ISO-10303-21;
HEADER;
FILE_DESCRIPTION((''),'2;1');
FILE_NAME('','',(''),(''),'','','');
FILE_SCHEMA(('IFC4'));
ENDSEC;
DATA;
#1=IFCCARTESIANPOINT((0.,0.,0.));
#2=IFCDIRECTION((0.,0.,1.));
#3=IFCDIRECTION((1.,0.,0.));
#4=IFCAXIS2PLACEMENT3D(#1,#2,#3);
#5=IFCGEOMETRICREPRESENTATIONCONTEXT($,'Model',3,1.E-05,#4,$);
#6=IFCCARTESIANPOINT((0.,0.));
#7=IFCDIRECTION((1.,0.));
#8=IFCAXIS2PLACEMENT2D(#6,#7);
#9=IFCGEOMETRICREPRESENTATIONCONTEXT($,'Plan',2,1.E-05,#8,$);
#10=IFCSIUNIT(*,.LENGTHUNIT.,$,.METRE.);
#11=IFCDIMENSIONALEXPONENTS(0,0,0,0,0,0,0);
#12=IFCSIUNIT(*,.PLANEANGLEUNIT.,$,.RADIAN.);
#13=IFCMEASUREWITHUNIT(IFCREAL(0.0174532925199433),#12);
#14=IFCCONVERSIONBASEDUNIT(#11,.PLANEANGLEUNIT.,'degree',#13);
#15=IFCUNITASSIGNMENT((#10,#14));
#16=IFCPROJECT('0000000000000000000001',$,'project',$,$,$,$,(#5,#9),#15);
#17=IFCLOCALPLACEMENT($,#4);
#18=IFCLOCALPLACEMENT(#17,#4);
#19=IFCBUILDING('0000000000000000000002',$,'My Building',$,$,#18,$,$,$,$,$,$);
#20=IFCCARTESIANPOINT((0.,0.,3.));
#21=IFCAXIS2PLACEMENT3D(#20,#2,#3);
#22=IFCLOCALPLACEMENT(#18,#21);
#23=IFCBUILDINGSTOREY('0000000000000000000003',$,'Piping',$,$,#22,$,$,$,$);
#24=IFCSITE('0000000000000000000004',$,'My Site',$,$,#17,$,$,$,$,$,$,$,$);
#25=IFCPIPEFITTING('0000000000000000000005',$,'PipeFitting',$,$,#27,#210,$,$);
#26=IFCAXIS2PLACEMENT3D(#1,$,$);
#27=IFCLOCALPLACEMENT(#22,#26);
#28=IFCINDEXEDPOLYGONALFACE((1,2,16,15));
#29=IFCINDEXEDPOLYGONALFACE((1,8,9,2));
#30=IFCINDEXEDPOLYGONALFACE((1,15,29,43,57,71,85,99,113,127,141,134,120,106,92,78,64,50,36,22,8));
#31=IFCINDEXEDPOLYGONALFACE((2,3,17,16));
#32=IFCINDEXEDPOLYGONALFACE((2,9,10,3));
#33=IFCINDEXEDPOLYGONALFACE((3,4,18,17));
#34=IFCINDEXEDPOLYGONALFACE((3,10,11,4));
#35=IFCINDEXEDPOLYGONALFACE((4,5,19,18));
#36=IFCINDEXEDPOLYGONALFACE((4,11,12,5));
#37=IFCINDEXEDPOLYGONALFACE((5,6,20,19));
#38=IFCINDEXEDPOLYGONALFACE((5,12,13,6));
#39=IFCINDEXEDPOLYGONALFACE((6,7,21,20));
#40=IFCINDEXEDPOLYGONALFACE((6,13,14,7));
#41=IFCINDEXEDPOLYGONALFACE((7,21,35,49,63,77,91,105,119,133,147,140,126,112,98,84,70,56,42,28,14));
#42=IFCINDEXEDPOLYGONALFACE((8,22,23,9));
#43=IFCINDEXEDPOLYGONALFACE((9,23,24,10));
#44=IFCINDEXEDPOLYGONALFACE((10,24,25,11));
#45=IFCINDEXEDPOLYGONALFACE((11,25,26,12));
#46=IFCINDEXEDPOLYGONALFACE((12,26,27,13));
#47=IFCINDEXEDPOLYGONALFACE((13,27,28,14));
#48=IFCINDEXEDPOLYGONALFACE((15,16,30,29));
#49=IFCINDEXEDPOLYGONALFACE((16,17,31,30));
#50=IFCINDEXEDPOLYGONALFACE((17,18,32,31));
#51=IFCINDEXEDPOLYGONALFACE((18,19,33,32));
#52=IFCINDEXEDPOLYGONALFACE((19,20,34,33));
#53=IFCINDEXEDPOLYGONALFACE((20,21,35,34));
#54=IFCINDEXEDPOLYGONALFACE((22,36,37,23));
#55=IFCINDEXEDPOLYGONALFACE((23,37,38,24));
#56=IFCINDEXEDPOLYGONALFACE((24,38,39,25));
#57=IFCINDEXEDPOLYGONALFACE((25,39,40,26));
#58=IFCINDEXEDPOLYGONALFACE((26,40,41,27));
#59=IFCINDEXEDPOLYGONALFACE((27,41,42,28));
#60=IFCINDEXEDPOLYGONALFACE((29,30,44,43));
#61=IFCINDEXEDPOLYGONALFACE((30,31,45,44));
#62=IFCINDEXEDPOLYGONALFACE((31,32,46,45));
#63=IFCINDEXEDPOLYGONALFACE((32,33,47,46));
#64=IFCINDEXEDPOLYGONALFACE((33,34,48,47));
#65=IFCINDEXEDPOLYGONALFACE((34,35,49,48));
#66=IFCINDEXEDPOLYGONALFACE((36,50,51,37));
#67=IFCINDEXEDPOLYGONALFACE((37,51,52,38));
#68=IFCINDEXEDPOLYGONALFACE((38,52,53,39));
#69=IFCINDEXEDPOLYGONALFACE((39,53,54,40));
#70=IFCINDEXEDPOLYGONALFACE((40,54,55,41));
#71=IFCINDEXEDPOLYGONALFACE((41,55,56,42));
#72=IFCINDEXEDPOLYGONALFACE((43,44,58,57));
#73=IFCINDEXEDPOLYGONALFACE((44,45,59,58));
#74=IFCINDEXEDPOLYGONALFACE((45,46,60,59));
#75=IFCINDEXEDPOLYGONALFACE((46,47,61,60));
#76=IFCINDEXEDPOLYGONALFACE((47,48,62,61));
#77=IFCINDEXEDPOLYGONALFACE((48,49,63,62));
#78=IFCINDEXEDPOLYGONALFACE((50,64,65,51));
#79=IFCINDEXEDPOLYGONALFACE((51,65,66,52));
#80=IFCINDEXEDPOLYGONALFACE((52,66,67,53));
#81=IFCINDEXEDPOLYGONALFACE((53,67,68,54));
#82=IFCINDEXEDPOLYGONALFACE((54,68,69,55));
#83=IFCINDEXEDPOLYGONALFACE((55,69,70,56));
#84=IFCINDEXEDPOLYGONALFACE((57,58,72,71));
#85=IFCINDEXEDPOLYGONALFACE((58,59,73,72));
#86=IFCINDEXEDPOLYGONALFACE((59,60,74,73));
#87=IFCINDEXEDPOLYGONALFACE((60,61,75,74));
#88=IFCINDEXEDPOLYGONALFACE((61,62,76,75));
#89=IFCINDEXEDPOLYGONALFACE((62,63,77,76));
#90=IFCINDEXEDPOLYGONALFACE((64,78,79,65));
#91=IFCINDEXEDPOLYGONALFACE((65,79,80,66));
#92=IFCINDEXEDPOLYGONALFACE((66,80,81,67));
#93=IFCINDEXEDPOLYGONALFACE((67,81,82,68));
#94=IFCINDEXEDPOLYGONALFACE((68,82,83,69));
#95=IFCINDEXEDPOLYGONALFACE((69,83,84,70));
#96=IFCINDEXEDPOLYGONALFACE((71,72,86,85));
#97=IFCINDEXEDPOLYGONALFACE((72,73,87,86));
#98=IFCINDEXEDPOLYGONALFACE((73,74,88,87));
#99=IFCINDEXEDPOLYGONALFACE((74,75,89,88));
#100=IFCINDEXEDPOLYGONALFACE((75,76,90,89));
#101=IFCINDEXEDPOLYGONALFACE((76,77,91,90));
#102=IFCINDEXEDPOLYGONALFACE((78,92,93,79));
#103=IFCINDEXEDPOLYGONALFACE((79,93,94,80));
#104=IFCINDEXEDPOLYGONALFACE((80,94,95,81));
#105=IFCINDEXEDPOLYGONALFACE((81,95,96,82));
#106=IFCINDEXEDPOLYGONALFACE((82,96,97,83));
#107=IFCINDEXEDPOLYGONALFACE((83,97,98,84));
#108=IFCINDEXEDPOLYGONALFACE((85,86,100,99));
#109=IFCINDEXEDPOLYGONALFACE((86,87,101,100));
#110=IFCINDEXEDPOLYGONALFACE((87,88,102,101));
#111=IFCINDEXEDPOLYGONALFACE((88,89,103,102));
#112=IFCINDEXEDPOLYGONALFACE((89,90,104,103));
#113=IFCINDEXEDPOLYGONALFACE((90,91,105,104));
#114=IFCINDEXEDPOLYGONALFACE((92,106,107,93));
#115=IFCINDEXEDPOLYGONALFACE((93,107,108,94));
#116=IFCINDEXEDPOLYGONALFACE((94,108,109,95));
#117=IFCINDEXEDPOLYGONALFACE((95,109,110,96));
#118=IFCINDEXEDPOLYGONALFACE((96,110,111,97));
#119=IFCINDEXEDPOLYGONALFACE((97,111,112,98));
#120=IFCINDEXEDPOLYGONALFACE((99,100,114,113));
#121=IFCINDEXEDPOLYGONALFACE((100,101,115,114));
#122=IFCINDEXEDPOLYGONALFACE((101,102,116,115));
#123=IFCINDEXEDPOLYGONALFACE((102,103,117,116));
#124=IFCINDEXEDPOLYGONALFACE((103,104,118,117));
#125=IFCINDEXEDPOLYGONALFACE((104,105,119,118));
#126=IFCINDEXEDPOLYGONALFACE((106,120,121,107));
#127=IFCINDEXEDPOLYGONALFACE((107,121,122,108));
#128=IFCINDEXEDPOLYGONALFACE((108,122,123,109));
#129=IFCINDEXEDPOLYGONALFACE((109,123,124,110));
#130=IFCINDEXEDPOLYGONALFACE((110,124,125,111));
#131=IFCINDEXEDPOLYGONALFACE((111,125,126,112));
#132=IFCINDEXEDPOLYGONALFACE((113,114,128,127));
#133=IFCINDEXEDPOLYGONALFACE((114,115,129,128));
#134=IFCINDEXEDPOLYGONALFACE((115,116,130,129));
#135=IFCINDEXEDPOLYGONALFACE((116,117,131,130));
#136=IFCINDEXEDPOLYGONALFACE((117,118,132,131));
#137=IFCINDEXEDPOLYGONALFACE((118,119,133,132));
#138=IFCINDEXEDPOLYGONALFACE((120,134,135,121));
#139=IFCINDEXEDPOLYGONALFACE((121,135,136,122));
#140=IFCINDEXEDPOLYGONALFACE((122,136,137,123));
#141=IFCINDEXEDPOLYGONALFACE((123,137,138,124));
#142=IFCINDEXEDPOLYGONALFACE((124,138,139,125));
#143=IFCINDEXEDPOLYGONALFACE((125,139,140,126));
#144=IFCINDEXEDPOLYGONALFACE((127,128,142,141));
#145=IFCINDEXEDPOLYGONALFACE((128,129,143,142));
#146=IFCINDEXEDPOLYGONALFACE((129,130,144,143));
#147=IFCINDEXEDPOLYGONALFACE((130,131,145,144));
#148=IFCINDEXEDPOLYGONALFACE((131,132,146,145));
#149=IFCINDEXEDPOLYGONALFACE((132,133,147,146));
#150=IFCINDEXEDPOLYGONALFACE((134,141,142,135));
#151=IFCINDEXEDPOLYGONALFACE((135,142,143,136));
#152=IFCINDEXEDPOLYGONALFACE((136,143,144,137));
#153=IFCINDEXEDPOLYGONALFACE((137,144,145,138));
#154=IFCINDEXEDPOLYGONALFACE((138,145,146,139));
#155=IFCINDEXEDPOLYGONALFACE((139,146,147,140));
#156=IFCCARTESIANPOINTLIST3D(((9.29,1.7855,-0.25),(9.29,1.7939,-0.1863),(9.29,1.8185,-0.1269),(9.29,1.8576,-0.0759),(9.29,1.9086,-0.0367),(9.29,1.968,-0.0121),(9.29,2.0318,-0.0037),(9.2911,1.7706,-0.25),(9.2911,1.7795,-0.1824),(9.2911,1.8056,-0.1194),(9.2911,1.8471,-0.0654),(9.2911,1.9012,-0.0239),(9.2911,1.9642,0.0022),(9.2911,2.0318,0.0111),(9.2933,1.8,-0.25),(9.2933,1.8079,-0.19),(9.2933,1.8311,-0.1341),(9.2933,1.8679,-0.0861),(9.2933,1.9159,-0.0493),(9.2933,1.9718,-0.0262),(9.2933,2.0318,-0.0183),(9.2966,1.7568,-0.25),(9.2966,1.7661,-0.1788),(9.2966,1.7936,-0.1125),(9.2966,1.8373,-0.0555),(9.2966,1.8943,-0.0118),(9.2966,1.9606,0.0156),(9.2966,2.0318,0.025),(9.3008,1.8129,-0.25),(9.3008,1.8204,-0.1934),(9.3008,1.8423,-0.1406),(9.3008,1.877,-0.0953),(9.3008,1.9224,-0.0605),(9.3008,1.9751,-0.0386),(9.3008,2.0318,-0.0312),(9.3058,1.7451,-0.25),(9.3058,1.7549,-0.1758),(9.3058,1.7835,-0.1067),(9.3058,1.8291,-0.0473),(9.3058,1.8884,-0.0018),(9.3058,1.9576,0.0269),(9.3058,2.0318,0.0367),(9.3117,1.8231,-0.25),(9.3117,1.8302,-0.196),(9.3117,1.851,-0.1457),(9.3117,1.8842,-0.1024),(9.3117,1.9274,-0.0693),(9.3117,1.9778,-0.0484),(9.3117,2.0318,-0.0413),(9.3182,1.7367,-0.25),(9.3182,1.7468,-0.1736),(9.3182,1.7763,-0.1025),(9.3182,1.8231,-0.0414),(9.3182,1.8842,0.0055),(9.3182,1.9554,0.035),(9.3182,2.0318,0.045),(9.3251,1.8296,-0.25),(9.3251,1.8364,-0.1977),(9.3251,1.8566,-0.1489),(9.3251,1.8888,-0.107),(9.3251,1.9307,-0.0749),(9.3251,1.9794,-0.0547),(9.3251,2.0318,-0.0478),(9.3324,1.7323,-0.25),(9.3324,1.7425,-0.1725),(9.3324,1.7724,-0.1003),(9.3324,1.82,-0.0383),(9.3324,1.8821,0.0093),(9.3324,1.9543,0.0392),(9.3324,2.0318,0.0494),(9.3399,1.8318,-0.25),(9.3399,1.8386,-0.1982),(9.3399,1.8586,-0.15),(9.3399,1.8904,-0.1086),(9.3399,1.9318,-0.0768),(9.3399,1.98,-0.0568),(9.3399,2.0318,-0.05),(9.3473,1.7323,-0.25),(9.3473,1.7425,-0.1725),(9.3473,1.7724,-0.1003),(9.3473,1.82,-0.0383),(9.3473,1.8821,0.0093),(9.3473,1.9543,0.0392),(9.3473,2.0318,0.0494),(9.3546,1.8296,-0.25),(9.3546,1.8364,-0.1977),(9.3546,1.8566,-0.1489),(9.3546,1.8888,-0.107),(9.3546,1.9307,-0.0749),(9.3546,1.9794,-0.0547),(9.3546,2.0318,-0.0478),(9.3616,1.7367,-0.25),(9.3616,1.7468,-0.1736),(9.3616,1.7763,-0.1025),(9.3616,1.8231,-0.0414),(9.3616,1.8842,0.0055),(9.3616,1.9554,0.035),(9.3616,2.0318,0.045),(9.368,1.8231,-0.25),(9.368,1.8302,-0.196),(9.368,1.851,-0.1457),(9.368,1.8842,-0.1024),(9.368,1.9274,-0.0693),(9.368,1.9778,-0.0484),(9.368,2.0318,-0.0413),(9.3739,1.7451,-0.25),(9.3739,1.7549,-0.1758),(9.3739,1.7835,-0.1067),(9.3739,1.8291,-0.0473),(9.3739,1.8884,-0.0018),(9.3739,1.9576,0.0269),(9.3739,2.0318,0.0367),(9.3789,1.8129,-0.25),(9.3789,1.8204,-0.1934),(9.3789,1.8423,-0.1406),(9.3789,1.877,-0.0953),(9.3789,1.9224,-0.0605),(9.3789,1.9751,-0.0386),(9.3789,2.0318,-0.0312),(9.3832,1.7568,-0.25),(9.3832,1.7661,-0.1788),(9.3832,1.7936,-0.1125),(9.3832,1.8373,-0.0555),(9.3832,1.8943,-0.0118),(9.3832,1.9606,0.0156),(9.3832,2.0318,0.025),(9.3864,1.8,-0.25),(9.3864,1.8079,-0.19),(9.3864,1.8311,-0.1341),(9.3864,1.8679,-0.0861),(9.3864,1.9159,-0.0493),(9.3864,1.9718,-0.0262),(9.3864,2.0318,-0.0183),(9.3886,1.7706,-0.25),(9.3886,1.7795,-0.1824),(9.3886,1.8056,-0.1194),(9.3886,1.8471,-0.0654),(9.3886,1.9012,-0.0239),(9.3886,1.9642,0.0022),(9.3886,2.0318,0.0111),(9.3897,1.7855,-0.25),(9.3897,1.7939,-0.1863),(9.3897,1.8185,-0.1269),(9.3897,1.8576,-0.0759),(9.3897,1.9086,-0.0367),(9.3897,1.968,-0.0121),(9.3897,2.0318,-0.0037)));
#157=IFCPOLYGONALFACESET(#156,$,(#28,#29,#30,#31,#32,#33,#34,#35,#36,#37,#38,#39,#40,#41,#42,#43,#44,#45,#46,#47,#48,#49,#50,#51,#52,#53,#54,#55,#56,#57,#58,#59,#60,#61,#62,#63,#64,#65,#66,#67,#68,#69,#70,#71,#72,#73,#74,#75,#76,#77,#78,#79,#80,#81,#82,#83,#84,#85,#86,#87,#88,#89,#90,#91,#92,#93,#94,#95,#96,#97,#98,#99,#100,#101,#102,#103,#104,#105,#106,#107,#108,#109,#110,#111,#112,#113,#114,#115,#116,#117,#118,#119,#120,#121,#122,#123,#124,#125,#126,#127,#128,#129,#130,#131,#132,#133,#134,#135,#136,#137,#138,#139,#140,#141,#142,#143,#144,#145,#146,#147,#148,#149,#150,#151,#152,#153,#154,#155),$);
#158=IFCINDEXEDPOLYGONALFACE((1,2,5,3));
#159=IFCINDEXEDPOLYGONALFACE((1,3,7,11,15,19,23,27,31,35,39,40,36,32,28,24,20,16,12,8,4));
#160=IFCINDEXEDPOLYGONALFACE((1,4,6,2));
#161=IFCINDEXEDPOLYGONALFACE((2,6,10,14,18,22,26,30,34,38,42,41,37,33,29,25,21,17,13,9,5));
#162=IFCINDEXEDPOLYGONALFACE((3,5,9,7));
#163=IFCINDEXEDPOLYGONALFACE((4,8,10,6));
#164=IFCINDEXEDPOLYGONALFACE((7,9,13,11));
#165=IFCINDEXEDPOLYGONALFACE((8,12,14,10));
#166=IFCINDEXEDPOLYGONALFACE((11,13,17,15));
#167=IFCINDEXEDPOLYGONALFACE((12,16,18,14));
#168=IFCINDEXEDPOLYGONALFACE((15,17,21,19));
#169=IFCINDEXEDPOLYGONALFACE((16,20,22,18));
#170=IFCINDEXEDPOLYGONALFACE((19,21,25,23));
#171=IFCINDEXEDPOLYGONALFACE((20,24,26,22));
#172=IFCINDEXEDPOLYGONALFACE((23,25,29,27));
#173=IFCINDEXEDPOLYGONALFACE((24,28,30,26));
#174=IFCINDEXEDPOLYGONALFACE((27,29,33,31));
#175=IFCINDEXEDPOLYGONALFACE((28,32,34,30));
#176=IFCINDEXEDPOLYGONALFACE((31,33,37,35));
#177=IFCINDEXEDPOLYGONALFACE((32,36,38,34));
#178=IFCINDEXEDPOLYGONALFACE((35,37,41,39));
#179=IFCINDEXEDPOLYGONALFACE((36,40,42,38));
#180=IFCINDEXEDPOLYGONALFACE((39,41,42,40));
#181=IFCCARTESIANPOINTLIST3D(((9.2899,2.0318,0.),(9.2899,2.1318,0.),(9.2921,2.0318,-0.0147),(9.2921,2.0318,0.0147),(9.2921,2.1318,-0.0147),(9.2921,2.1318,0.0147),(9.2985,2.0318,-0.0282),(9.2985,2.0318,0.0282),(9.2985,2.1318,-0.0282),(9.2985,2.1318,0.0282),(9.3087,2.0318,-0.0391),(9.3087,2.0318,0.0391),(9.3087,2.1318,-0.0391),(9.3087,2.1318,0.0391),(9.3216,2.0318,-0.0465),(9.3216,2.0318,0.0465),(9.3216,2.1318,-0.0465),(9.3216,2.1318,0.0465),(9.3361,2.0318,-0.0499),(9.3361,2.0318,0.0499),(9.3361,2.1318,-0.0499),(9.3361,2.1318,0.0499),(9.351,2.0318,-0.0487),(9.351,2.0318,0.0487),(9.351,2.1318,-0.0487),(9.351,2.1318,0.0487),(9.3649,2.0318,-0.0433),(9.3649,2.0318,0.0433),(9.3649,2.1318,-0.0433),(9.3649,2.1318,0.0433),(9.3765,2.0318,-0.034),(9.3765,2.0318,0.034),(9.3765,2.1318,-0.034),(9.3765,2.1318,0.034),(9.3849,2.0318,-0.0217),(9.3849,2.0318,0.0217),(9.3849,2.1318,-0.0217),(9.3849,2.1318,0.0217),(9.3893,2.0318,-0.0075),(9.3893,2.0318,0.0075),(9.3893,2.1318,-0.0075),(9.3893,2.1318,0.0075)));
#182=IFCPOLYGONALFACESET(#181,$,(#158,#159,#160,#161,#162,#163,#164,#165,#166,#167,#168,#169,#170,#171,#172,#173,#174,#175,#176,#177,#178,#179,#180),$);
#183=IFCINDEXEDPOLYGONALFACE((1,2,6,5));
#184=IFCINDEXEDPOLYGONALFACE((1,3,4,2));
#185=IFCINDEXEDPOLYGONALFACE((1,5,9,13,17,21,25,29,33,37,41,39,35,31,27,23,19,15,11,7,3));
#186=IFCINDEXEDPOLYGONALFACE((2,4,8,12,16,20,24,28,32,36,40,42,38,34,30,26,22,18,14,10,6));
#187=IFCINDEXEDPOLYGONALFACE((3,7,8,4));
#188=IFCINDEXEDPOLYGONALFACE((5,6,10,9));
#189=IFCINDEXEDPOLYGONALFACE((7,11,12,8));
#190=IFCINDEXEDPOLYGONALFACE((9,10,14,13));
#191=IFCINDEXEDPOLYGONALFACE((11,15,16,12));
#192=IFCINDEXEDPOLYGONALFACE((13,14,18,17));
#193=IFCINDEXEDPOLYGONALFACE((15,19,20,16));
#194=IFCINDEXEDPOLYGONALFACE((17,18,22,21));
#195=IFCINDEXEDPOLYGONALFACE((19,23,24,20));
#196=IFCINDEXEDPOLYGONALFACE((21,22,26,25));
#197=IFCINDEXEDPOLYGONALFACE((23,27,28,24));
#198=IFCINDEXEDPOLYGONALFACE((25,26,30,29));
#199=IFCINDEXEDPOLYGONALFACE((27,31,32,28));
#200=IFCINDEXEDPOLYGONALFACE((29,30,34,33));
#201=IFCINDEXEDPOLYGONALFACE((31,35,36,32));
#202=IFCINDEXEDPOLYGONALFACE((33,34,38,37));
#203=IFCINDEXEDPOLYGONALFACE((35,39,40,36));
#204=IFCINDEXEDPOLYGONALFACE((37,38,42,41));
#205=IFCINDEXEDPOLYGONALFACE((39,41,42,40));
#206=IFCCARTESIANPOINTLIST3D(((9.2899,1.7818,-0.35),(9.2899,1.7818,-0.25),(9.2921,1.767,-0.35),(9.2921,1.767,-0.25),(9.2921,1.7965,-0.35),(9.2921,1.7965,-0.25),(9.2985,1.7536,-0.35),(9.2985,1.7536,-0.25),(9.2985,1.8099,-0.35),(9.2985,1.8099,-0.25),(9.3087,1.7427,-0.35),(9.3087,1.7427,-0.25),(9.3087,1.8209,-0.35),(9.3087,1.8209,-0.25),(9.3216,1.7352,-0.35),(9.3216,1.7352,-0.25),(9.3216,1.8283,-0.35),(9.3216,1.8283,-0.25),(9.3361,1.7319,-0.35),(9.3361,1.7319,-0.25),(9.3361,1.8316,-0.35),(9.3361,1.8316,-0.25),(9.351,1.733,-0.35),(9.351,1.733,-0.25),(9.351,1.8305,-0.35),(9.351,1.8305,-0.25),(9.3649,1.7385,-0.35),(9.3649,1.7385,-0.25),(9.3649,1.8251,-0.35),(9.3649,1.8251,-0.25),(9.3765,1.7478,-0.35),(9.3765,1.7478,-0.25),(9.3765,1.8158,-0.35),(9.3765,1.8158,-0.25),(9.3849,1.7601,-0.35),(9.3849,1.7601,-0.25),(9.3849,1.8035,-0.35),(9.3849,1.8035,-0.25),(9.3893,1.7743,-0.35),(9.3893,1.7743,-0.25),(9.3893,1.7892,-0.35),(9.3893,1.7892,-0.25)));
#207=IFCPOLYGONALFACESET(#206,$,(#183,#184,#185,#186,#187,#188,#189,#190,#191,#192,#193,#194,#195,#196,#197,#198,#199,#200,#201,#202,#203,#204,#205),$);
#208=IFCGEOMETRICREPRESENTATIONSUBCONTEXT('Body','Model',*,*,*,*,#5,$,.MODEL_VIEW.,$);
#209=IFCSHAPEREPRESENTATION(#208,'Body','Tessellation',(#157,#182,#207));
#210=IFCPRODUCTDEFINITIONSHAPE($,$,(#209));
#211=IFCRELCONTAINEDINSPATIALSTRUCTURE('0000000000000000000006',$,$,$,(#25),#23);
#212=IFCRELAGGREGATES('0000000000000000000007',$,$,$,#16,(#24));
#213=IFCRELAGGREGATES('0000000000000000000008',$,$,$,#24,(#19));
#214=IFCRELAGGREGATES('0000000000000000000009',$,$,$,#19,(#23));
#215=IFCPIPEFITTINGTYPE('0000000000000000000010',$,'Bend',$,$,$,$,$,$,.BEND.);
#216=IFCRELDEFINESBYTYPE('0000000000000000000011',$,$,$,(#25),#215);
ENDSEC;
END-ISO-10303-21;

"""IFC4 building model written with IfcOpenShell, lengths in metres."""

from ifc_helpers import new_model, entity, si_unit, converted_unit, frame, origin_with_axes, origin_2d_with_axis, place, context, subcontext, project, spatial, circle, extrude, source, transform, mapped, type_object, type_shapes, element, save


model = new_model("IFC4")

# Units and contexts
model_context = context("Model", 3, precision=1e-05, world=origin_with_axes())
plan_context = context("Plan", 2, precision=1e-05, world=origin_2d_with_axis())
body_context = subcontext(model_context, "Body", "Model", "MODEL_VIEW")
ifc_project = project(units=[si_unit("LENGTHUNIT", "METRE"), converted_unit("PLANEANGLEUNIT", "degree", entity("IfcReal", 0.0174532925199433), si_unit("PLANEANGLEUNIT", "RADIAN"), dimensions=[0, 0, 0, 0, 0, 0, 0])], contexts=[model_context, plan_context])

# Site, building, storey
site_placement = place(None, origin_with_axes())
site = spatial("IfcSite", under=ifc_project, at=site_placement, Name="My Site")
building_placement = place(site_placement, origin_with_axes())
building = spatial("IfcBuilding", under=site, at=building_placement, Name="My Building")
storey_placement = place(building_placement, frame((0.0, 0.0, 3.0), z_axis=(0.0, 0.0, 1.0), x_axis=(1.0, 0.0, 0.0)))
storey = spatial("IfcBuildingStorey", under=building, at=storey_placement, Name="Piping")

# Pipe fitting
pipe_fitting_type = type_object("IfcPipeFittingType", Name="Bend", PredefinedType="BEND")
shared_shape = source(origin_with_axes(), body_context, "Body", "SolidModel", [
    entity("IfcSweptDiskSolid", entity("IfcIndexedPolyCurve", entity("IfcCartesianPointList3D", [[0.0, 0.0, -0.1], [0.0, -0.0732, -0.2768], [0.0, -0.25, -0.35]]), [entity("IfcArcIndex", [1, 2, 3])]), 0.05),
    extrude(circle(Radius=0.05), origin_with_axes(), (0.0, 0.0, -1.0), 0.1),
    extrude(circle(Radius=0.05), frame((0.0, -0.25, -0.35), z_axis=(0.0, -1.0, 0.0), x_axis=(1.0, 0.0, 0.0)), (0.0, 0.0, 1.0), 0.1),
])
type_shapes(pipe_fitting_type, [shared_shape])
for number, where, z_axis, x_axis, name in (
    (1, (9.3399, 2.1318, 0.0), (0.0, 1.0, 0.0), (-1.0, 0.0, 0.0), "PipeFitting"),
):
    element("IfcPipeFitting", number, at=place(storey_placement, frame(where, z_axis=z_axis, x_axis=x_axis)), inside=storey, type_object=pipe_fitting_type, Name=name, context=body_context, shape_type="MappedRepresentation", body=[
        mapped(shared_shape, transform((0.0, 0.0, 0.0), x_axis=(1.0, 0.0, 0.0), y_axis=(0.0, 1.0, 0.0), z_axis=(0.0, 0.0, 1.0), scale=1.0)),
    ])

save(model, "model.ifc")
